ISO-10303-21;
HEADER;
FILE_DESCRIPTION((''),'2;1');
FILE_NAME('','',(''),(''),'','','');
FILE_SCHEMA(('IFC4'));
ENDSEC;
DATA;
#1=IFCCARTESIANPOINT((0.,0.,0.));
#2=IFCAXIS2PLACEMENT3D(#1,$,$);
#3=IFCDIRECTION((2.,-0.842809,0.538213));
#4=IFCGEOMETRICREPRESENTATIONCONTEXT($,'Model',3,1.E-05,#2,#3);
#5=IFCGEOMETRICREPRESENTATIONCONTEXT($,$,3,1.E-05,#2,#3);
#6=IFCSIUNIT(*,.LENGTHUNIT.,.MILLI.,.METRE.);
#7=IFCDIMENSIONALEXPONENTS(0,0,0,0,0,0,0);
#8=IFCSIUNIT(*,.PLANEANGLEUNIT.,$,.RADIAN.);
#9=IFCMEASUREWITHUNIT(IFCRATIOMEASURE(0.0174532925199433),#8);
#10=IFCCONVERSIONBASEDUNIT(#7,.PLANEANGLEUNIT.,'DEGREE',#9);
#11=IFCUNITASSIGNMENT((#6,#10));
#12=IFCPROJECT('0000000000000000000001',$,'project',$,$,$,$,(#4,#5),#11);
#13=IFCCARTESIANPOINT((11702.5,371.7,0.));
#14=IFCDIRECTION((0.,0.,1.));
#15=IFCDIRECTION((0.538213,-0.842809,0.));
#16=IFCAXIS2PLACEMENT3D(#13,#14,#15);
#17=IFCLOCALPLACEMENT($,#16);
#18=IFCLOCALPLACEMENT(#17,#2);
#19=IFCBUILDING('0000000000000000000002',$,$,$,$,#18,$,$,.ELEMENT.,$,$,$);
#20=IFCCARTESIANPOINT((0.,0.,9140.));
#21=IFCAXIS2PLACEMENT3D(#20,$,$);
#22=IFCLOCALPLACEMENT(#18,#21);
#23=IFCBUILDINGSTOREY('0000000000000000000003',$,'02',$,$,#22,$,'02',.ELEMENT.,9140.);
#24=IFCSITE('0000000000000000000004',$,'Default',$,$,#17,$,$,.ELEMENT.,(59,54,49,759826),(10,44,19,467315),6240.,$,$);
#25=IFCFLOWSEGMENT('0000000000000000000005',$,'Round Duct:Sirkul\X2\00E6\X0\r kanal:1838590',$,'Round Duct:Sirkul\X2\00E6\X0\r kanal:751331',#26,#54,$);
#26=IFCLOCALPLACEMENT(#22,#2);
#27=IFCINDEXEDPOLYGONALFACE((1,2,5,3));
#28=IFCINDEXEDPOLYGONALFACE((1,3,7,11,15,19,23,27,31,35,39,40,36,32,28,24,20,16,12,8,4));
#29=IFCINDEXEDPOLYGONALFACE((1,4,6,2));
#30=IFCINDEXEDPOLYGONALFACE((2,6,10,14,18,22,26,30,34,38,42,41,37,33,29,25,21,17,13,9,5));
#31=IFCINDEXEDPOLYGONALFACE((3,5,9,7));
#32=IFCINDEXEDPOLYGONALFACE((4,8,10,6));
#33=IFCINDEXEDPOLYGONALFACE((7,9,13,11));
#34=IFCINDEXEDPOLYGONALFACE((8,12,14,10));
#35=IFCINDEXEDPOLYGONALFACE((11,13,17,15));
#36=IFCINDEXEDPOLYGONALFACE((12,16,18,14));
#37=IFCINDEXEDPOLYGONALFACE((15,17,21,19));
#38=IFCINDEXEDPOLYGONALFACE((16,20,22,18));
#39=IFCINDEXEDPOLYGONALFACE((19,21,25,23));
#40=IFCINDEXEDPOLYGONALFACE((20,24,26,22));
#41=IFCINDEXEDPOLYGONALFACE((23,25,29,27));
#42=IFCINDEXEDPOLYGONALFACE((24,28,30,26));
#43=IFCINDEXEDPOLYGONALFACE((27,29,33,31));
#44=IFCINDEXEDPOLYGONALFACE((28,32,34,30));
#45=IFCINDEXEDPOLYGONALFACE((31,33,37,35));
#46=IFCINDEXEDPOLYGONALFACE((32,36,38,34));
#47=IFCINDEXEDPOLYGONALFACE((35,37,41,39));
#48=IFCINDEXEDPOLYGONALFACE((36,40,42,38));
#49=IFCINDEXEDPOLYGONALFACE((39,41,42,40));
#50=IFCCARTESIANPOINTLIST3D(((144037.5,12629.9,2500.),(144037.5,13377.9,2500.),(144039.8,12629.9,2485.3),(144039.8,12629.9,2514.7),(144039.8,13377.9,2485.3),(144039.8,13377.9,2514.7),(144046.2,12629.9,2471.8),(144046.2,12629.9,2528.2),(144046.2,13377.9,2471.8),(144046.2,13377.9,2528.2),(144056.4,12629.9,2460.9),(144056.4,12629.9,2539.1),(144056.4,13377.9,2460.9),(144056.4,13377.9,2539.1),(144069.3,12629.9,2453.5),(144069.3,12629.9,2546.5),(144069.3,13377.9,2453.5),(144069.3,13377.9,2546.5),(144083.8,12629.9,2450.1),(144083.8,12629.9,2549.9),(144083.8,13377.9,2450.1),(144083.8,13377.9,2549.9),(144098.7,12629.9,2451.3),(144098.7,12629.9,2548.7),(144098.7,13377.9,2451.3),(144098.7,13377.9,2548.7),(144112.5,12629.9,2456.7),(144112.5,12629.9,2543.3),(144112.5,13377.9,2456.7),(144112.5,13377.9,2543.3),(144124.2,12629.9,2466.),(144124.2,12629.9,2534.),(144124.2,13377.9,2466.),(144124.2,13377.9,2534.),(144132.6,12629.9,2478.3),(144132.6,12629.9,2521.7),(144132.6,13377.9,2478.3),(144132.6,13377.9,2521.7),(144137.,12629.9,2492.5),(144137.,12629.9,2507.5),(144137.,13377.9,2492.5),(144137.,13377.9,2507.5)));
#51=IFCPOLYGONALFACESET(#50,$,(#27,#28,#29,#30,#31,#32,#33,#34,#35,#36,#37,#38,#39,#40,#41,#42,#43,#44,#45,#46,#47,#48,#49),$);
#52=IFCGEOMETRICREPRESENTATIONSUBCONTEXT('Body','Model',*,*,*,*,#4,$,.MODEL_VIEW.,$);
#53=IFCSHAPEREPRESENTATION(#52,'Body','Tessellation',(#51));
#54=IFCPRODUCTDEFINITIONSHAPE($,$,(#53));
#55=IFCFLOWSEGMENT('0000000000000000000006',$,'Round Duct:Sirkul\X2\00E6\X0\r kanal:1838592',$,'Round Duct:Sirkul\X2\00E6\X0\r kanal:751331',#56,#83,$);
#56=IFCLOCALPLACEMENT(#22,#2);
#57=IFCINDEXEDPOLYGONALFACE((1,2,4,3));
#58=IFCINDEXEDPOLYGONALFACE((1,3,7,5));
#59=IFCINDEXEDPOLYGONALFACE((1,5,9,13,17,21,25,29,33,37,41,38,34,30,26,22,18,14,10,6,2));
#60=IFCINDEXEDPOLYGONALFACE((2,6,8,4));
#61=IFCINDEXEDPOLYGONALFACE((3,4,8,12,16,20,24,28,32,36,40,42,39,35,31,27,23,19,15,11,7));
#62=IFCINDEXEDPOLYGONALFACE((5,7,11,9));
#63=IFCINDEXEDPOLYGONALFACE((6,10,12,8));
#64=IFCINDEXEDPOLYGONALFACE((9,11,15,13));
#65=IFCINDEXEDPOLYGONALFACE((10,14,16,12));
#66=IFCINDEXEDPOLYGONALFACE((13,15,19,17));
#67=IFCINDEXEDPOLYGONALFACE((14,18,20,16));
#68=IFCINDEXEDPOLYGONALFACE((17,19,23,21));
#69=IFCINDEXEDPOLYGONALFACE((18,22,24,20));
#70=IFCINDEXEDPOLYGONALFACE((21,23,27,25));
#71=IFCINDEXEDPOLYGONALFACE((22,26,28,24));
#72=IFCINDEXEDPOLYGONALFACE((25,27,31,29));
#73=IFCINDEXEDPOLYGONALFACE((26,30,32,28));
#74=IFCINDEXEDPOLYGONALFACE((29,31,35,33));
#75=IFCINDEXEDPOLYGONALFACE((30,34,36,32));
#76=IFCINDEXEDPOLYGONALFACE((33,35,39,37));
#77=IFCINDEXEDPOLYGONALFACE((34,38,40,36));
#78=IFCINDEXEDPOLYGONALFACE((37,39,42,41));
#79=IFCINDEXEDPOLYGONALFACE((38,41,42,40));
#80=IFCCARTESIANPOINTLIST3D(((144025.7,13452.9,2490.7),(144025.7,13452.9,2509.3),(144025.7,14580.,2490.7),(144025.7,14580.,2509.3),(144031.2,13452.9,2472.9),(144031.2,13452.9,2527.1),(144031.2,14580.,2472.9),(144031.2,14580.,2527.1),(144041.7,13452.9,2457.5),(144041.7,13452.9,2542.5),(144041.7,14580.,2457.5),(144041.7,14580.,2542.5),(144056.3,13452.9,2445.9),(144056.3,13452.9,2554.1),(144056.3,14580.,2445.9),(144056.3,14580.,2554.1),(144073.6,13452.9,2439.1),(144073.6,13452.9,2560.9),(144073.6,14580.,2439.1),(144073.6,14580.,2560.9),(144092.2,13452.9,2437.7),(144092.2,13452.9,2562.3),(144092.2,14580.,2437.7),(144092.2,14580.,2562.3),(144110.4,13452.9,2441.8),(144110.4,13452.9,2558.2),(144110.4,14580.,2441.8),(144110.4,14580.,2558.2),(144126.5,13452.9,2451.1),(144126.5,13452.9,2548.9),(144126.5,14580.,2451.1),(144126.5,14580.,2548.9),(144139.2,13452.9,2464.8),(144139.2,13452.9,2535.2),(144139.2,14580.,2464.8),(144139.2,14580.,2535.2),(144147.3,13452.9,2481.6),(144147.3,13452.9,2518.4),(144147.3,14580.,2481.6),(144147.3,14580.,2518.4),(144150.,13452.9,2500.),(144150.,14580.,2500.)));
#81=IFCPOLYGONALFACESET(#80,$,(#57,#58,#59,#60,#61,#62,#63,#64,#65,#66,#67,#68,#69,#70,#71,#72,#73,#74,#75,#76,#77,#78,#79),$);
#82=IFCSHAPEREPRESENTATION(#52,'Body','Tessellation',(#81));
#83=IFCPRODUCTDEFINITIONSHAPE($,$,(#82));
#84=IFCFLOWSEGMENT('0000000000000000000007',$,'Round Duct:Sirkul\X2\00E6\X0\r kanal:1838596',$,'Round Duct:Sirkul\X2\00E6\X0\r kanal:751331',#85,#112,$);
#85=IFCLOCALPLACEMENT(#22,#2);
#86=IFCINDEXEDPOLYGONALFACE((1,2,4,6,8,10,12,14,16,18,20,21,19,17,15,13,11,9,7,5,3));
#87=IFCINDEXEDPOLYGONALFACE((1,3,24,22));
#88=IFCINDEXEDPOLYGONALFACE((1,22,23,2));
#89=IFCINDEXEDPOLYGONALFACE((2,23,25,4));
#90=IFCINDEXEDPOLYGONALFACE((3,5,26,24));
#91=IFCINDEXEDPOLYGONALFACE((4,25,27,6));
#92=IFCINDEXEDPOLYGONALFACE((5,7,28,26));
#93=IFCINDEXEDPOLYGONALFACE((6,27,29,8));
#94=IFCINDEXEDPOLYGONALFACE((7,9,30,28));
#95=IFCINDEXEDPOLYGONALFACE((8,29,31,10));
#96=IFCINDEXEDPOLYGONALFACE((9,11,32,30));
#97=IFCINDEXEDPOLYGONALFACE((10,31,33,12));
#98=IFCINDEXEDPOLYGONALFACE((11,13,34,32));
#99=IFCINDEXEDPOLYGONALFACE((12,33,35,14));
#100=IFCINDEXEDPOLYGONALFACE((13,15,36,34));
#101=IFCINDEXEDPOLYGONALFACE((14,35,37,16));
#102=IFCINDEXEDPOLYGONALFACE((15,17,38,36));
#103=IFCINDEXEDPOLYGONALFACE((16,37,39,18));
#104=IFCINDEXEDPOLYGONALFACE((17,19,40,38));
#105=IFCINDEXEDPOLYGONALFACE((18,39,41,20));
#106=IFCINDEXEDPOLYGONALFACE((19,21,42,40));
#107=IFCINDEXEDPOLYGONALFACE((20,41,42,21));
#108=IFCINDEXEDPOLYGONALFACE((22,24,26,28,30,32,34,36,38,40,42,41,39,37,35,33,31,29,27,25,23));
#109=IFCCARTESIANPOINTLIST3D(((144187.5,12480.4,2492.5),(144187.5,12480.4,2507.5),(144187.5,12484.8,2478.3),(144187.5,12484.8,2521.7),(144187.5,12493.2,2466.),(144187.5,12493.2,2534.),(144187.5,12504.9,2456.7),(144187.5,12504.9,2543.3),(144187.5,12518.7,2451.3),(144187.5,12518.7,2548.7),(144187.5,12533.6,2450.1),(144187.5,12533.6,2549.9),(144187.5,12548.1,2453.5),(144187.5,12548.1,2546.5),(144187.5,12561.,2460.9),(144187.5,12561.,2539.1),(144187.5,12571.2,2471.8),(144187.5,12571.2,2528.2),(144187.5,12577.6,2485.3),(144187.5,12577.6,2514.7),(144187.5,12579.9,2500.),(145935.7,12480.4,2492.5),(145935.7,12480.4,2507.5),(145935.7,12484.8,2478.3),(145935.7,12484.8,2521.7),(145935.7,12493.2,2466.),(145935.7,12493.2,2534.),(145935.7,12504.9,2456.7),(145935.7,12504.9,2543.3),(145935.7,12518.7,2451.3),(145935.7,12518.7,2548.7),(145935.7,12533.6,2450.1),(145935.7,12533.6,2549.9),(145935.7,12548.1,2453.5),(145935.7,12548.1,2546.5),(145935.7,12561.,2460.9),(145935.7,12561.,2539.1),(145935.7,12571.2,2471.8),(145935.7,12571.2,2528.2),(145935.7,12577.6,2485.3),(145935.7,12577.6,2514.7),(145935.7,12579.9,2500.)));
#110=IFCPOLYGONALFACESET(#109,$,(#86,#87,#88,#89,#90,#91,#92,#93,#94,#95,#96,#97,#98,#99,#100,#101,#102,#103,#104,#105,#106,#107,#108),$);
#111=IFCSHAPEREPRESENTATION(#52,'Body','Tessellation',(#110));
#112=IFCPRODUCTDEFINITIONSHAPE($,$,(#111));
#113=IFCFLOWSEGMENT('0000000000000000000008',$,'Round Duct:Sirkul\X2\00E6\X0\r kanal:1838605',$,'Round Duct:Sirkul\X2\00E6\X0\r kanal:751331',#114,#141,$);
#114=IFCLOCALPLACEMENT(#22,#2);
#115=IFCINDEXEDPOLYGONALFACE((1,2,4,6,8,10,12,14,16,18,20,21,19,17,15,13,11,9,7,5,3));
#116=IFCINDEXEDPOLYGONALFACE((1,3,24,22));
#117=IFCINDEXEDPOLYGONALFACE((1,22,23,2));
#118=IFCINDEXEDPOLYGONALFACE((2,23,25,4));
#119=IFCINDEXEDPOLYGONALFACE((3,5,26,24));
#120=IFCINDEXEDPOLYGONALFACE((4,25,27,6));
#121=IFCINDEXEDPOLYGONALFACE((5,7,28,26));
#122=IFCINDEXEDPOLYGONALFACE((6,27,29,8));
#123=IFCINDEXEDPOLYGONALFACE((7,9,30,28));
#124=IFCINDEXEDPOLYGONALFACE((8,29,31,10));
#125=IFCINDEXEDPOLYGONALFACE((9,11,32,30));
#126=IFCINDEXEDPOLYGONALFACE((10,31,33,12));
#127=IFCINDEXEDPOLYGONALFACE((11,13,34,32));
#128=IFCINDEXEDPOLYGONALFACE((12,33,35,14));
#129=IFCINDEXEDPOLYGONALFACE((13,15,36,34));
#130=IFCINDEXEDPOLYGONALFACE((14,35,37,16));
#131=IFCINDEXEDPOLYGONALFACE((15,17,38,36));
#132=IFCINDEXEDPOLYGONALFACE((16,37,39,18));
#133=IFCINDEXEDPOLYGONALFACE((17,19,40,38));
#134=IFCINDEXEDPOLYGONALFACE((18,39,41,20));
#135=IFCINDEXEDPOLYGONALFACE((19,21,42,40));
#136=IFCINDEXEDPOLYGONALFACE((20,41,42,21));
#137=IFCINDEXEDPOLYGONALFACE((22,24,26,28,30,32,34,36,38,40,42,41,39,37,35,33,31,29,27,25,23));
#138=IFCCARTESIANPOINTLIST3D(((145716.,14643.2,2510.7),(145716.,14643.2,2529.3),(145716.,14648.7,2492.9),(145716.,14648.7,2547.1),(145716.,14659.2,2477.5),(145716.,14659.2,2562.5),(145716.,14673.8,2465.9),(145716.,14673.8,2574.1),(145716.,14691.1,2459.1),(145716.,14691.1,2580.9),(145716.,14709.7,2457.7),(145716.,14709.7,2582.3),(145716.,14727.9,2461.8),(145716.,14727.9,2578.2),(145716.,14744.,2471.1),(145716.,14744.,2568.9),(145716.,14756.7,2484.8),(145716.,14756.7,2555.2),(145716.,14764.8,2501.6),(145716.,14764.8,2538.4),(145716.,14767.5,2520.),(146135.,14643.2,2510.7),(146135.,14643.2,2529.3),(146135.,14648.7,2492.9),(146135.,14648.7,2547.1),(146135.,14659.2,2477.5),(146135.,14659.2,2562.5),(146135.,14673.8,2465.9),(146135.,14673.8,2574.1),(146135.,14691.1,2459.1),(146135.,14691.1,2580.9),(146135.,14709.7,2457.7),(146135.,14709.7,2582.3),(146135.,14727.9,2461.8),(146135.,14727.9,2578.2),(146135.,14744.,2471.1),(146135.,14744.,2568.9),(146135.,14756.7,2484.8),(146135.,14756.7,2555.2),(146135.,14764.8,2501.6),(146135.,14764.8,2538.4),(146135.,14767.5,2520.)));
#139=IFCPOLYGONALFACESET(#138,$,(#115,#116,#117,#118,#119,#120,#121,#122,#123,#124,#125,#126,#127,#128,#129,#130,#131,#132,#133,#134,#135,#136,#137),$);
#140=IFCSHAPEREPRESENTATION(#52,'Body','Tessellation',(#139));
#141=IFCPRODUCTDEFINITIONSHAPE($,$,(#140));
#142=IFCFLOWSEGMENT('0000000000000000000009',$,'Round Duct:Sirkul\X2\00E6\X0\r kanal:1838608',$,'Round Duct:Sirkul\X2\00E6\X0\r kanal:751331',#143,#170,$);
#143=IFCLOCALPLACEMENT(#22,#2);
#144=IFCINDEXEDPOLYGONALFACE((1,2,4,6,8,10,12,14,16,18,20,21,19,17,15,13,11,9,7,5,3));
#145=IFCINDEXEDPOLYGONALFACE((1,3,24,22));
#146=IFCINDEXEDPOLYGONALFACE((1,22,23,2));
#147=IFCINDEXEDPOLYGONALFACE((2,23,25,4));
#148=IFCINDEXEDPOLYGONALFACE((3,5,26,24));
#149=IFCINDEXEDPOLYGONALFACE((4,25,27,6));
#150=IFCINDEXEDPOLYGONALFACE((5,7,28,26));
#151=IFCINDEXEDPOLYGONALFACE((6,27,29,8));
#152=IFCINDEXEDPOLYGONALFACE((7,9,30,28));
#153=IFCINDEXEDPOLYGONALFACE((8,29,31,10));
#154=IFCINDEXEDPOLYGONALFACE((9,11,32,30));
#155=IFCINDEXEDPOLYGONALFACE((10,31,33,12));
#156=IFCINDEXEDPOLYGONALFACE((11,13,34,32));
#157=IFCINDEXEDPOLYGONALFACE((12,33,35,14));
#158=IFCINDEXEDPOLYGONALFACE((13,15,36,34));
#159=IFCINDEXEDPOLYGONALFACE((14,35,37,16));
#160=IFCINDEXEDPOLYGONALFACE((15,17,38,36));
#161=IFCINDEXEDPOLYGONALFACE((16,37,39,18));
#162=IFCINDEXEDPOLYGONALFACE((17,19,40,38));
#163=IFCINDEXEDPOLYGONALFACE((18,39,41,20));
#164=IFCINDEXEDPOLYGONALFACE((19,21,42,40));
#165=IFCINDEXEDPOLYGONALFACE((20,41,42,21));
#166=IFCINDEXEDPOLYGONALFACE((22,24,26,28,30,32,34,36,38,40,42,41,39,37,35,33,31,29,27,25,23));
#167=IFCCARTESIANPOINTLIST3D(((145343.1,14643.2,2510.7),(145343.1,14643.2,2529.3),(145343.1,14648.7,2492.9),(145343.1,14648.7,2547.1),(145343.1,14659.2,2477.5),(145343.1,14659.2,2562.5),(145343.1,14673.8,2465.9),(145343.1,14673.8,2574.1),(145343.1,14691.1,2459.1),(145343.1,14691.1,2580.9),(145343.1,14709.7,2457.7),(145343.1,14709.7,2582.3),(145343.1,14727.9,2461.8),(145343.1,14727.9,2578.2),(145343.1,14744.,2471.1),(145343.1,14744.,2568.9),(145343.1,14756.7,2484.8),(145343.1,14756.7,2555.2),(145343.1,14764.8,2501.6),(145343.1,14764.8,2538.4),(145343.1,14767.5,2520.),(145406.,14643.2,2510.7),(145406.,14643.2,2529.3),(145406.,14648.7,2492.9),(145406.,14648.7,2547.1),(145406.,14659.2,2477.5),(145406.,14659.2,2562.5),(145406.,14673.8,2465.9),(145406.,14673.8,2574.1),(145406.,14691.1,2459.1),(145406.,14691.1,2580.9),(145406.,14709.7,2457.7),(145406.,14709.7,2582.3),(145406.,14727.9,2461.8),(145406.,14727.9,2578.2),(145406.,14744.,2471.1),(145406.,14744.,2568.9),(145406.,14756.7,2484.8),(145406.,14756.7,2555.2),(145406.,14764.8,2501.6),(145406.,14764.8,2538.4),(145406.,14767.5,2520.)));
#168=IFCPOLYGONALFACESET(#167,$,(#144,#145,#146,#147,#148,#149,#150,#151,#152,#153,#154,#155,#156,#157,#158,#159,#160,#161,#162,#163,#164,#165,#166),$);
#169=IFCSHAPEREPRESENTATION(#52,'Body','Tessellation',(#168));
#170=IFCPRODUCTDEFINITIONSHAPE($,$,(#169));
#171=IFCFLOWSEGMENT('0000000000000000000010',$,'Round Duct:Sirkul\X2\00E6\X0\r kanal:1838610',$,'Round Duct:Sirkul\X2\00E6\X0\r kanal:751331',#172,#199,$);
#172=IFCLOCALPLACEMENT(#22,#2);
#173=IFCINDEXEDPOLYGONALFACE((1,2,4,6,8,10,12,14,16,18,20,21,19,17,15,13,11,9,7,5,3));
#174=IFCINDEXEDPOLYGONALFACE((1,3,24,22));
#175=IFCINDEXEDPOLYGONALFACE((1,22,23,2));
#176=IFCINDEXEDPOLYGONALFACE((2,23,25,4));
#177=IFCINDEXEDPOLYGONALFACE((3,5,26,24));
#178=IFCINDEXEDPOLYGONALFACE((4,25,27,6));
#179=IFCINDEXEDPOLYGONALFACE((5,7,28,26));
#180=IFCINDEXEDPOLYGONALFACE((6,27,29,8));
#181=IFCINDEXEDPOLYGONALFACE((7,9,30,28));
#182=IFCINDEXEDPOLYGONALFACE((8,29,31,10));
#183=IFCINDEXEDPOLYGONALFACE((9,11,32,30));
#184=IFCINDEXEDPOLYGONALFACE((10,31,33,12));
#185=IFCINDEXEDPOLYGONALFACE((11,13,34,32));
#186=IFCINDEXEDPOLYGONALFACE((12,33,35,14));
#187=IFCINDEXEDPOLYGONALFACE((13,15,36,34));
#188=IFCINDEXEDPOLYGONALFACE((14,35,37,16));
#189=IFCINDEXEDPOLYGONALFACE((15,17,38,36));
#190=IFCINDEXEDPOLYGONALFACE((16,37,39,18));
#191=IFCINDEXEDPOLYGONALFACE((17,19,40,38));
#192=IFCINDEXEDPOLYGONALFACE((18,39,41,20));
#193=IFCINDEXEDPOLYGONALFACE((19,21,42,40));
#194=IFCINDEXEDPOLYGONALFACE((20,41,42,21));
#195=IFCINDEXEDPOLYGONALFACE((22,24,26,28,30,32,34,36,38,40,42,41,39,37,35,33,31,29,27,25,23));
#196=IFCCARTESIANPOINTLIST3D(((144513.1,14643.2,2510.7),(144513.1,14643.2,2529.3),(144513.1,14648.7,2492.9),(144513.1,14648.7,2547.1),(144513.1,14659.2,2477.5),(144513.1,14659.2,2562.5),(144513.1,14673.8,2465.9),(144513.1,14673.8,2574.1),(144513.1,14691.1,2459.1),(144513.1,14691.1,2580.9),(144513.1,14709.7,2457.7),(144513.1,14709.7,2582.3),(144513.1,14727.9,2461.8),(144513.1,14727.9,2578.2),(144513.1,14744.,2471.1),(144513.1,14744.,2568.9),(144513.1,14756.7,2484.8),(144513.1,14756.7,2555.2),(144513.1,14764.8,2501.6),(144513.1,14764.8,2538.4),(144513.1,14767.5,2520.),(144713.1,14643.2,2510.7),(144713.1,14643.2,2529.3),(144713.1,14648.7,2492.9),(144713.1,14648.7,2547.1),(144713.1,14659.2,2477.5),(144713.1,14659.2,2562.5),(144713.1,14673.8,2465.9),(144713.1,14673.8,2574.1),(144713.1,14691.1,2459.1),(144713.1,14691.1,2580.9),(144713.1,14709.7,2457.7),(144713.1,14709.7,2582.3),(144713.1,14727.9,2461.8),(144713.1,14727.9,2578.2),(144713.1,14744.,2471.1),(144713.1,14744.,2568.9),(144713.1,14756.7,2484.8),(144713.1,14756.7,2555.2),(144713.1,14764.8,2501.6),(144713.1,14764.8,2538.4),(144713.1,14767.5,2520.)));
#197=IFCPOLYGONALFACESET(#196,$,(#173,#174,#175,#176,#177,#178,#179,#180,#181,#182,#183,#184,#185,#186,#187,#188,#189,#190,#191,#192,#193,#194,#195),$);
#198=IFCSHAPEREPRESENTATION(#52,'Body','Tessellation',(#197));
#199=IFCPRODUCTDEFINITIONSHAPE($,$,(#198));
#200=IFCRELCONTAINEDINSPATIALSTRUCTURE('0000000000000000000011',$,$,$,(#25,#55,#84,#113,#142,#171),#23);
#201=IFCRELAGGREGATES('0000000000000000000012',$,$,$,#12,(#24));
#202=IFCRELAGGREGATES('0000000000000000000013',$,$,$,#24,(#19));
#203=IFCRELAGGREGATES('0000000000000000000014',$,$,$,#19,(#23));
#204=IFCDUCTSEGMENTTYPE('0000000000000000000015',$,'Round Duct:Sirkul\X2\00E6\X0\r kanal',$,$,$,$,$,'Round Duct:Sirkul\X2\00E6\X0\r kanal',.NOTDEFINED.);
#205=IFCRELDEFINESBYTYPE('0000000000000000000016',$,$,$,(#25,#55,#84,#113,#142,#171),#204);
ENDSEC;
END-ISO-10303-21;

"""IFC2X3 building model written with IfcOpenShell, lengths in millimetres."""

from ifc_helpers import new_model, entity, si_unit, converted_unit, direction, frame, frame_2d, origin, origin_2d_with_axis, place, context, subcontext, project, spatial, circle, extrude, type_object, element, save


model = new_model("IFC2X3")

# Units and contexts
model_context = context("Model", 3, precision=1e-05, world=origin(), true_north=direction((2.0, -0.842809, 0.538213)))
context_of_model = context(None, 3, precision=1e-05, world=origin(), true_north=direction((2.0, -0.842809, 0.538213)))
body_context = subcontext(model_context, "Body", "Model", "MODEL_VIEW")
ifc_project = project(units=[si_unit("LENGTHUNIT", "METRE", prefix="MILLI"), converted_unit("PLANEANGLEUNIT", "DEGREE", entity("IfcRatioMeasure", 0.0174532925199433), si_unit("PLANEANGLEUNIT", "RADIAN"), dimensions=[0, 0, 0, 0, 0, 0, 0])], contexts=[model_context, context_of_model])

# Site, building, storey
site_placement = place(None, frame((11702.5, 371.7, 0.0), z_axis=(0.0, 0.0, 1.0), x_axis=(0.538213, -0.842809, 0.0)))
site = spatial("IfcSite", under=ifc_project, at=site_placement, Name="Default", CompositionType="ELEMENT", RefLatitude=(59, 54, 49, 759826), RefLongitude=(10, 44, 19, 467315), RefElevation=6240.0)
building_placement = place(site_placement, origin())
building = spatial("IfcBuilding", under=site, at=building_placement, CompositionType="ELEMENT")
storey_placement = place(building_placement, frame((0.0, 0.0, 9140.0)))
storey = spatial("IfcBuildingStorey", under=building, at=storey_placement, Name="02", LongName="02", CompositionType="ELEMENT", Elevation=9140.0)

# Flow segments
duct_segment_type_1 = type_object("IfcDuctSegmentType", Name="Round Duct:Sirkulær kanal", ElementType="Round Duct:Sirkulær kanal", PredefinedType="NOTDEFINED")
flow_segment_1_placement = place(storey_placement, origin())
element("IfcFlowSegment", 1, at=flow_segment_1_placement, inside=storey, type_object=duct_segment_type_1, Name="Round Duct:Sirkulær kanal:1838590", ObjectType="Round Duct:Sirkulær kanal:751331", context=body_context, shape_type="SweptSolid", body=[
    extrude(circle(Radius=50.0, at=origin_2d_with_axis()), frame((144087.5, 12629.9, 2500.0), z_axis=(0.0, 1.0, 0.0), x_axis=(-1.0, 0.0, 0.0)), (0.0, 0.0, 1.0), 748.0),
])
flow_segment_2_placement = place(storey_placement, origin())
element("IfcFlowSegment", 2, at=flow_segment_2_placement, inside=storey, type_object=duct_segment_type_1, Name="Round Duct:Sirkulær kanal:1838592", ObjectType="Round Duct:Sirkulær kanal:751331", context=body_context, shape_type="SweptSolid", body=[
    extrude(circle(Radius=62.5, at=origin_2d_with_axis()), frame((144087.5, 13452.9, 2500.0), z_axis=(0.0, 1.0, 0.0), x_axis=(1.0, 0.0, 0.0)), (0.0, 0.0, 1.0), 1127.2),
])
flow_segment_3_placement = place(storey_placement, origin())
element("IfcFlowSegment", 3, at=flow_segment_3_placement, inside=storey, type_object=duct_segment_type_1, Name="Round Duct:Sirkulær kanal:1838596", ObjectType="Round Duct:Sirkulær kanal:751331", context=body_context, shape_type="SweptSolid", body=[
    extrude(circle(Radius=50.0, at=frame_2d((0.0, 0.0), x_axis=(1.0, 0.0))), frame((144187.5, 12529.9, 2500.0), z_axis=(1.0, 0.0, 0.0), x_axis=(0.0, 1.0, 0.0)), (0.0, 0.0, 1.0), 1748.2),
])
flow_segment_4_placement = place(storey_placement, origin())
element("IfcFlowSegment", 4, at=flow_segment_4_placement, inside=storey, type_object=duct_segment_type_1, Name="Round Duct:Sirkulær kanal:1838605", ObjectType="Round Duct:Sirkulær kanal:751331", context=body_context, shape_type="SweptSolid", body=[
    extrude(circle(Radius=62.5, at=origin_2d_with_axis()), frame((145716.0, 14705.0, 2520.0), z_axis=(1.0, 0.0, 0.0), x_axis=(0.0, 1.0, 0.0)), (0.0, 0.0, 1.0), 419.1),
])
flow_segment_5_placement = place(storey_placement, origin())
element("IfcFlowSegment", 5, at=flow_segment_5_placement, inside=storey, type_object=duct_segment_type_1, Name="Round Duct:Sirkulær kanal:1838608", ObjectType="Round Duct:Sirkulær kanal:751331", context=body_context, shape_type="SweptSolid", body=[
    extrude(circle(Radius=62.5, at=origin_2d_with_axis()), frame((145343.1, 14705.0, 2520.0), z_axis=(1.0, 0.0, 0.0), x_axis=(0.0, 1.0, 0.0)), (0.0, 0.0, 1.0), 62.9),
])
flow_segment_6_placement = place(storey_placement, origin())
element("IfcFlowSegment", 6, at=flow_segment_6_placement, inside=storey, type_object=duct_segment_type_1, Name="Round Duct:Sirkulær kanal:1838610", ObjectType="Round Duct:Sirkulær kanal:751331", context=body_context, shape_type="SweptSolid", body=[
    extrude(circle(Radius=62.5, at=origin_2d_with_axis()), frame((144513.1, 14705.0, 2520.0), z_axis=(1.0, 0.0, 0.0), x_axis=(0.0, 1.0, 0.0)), (0.0, 0.0, 1.0), 200.0),
])

save(model, "model.ifc")
